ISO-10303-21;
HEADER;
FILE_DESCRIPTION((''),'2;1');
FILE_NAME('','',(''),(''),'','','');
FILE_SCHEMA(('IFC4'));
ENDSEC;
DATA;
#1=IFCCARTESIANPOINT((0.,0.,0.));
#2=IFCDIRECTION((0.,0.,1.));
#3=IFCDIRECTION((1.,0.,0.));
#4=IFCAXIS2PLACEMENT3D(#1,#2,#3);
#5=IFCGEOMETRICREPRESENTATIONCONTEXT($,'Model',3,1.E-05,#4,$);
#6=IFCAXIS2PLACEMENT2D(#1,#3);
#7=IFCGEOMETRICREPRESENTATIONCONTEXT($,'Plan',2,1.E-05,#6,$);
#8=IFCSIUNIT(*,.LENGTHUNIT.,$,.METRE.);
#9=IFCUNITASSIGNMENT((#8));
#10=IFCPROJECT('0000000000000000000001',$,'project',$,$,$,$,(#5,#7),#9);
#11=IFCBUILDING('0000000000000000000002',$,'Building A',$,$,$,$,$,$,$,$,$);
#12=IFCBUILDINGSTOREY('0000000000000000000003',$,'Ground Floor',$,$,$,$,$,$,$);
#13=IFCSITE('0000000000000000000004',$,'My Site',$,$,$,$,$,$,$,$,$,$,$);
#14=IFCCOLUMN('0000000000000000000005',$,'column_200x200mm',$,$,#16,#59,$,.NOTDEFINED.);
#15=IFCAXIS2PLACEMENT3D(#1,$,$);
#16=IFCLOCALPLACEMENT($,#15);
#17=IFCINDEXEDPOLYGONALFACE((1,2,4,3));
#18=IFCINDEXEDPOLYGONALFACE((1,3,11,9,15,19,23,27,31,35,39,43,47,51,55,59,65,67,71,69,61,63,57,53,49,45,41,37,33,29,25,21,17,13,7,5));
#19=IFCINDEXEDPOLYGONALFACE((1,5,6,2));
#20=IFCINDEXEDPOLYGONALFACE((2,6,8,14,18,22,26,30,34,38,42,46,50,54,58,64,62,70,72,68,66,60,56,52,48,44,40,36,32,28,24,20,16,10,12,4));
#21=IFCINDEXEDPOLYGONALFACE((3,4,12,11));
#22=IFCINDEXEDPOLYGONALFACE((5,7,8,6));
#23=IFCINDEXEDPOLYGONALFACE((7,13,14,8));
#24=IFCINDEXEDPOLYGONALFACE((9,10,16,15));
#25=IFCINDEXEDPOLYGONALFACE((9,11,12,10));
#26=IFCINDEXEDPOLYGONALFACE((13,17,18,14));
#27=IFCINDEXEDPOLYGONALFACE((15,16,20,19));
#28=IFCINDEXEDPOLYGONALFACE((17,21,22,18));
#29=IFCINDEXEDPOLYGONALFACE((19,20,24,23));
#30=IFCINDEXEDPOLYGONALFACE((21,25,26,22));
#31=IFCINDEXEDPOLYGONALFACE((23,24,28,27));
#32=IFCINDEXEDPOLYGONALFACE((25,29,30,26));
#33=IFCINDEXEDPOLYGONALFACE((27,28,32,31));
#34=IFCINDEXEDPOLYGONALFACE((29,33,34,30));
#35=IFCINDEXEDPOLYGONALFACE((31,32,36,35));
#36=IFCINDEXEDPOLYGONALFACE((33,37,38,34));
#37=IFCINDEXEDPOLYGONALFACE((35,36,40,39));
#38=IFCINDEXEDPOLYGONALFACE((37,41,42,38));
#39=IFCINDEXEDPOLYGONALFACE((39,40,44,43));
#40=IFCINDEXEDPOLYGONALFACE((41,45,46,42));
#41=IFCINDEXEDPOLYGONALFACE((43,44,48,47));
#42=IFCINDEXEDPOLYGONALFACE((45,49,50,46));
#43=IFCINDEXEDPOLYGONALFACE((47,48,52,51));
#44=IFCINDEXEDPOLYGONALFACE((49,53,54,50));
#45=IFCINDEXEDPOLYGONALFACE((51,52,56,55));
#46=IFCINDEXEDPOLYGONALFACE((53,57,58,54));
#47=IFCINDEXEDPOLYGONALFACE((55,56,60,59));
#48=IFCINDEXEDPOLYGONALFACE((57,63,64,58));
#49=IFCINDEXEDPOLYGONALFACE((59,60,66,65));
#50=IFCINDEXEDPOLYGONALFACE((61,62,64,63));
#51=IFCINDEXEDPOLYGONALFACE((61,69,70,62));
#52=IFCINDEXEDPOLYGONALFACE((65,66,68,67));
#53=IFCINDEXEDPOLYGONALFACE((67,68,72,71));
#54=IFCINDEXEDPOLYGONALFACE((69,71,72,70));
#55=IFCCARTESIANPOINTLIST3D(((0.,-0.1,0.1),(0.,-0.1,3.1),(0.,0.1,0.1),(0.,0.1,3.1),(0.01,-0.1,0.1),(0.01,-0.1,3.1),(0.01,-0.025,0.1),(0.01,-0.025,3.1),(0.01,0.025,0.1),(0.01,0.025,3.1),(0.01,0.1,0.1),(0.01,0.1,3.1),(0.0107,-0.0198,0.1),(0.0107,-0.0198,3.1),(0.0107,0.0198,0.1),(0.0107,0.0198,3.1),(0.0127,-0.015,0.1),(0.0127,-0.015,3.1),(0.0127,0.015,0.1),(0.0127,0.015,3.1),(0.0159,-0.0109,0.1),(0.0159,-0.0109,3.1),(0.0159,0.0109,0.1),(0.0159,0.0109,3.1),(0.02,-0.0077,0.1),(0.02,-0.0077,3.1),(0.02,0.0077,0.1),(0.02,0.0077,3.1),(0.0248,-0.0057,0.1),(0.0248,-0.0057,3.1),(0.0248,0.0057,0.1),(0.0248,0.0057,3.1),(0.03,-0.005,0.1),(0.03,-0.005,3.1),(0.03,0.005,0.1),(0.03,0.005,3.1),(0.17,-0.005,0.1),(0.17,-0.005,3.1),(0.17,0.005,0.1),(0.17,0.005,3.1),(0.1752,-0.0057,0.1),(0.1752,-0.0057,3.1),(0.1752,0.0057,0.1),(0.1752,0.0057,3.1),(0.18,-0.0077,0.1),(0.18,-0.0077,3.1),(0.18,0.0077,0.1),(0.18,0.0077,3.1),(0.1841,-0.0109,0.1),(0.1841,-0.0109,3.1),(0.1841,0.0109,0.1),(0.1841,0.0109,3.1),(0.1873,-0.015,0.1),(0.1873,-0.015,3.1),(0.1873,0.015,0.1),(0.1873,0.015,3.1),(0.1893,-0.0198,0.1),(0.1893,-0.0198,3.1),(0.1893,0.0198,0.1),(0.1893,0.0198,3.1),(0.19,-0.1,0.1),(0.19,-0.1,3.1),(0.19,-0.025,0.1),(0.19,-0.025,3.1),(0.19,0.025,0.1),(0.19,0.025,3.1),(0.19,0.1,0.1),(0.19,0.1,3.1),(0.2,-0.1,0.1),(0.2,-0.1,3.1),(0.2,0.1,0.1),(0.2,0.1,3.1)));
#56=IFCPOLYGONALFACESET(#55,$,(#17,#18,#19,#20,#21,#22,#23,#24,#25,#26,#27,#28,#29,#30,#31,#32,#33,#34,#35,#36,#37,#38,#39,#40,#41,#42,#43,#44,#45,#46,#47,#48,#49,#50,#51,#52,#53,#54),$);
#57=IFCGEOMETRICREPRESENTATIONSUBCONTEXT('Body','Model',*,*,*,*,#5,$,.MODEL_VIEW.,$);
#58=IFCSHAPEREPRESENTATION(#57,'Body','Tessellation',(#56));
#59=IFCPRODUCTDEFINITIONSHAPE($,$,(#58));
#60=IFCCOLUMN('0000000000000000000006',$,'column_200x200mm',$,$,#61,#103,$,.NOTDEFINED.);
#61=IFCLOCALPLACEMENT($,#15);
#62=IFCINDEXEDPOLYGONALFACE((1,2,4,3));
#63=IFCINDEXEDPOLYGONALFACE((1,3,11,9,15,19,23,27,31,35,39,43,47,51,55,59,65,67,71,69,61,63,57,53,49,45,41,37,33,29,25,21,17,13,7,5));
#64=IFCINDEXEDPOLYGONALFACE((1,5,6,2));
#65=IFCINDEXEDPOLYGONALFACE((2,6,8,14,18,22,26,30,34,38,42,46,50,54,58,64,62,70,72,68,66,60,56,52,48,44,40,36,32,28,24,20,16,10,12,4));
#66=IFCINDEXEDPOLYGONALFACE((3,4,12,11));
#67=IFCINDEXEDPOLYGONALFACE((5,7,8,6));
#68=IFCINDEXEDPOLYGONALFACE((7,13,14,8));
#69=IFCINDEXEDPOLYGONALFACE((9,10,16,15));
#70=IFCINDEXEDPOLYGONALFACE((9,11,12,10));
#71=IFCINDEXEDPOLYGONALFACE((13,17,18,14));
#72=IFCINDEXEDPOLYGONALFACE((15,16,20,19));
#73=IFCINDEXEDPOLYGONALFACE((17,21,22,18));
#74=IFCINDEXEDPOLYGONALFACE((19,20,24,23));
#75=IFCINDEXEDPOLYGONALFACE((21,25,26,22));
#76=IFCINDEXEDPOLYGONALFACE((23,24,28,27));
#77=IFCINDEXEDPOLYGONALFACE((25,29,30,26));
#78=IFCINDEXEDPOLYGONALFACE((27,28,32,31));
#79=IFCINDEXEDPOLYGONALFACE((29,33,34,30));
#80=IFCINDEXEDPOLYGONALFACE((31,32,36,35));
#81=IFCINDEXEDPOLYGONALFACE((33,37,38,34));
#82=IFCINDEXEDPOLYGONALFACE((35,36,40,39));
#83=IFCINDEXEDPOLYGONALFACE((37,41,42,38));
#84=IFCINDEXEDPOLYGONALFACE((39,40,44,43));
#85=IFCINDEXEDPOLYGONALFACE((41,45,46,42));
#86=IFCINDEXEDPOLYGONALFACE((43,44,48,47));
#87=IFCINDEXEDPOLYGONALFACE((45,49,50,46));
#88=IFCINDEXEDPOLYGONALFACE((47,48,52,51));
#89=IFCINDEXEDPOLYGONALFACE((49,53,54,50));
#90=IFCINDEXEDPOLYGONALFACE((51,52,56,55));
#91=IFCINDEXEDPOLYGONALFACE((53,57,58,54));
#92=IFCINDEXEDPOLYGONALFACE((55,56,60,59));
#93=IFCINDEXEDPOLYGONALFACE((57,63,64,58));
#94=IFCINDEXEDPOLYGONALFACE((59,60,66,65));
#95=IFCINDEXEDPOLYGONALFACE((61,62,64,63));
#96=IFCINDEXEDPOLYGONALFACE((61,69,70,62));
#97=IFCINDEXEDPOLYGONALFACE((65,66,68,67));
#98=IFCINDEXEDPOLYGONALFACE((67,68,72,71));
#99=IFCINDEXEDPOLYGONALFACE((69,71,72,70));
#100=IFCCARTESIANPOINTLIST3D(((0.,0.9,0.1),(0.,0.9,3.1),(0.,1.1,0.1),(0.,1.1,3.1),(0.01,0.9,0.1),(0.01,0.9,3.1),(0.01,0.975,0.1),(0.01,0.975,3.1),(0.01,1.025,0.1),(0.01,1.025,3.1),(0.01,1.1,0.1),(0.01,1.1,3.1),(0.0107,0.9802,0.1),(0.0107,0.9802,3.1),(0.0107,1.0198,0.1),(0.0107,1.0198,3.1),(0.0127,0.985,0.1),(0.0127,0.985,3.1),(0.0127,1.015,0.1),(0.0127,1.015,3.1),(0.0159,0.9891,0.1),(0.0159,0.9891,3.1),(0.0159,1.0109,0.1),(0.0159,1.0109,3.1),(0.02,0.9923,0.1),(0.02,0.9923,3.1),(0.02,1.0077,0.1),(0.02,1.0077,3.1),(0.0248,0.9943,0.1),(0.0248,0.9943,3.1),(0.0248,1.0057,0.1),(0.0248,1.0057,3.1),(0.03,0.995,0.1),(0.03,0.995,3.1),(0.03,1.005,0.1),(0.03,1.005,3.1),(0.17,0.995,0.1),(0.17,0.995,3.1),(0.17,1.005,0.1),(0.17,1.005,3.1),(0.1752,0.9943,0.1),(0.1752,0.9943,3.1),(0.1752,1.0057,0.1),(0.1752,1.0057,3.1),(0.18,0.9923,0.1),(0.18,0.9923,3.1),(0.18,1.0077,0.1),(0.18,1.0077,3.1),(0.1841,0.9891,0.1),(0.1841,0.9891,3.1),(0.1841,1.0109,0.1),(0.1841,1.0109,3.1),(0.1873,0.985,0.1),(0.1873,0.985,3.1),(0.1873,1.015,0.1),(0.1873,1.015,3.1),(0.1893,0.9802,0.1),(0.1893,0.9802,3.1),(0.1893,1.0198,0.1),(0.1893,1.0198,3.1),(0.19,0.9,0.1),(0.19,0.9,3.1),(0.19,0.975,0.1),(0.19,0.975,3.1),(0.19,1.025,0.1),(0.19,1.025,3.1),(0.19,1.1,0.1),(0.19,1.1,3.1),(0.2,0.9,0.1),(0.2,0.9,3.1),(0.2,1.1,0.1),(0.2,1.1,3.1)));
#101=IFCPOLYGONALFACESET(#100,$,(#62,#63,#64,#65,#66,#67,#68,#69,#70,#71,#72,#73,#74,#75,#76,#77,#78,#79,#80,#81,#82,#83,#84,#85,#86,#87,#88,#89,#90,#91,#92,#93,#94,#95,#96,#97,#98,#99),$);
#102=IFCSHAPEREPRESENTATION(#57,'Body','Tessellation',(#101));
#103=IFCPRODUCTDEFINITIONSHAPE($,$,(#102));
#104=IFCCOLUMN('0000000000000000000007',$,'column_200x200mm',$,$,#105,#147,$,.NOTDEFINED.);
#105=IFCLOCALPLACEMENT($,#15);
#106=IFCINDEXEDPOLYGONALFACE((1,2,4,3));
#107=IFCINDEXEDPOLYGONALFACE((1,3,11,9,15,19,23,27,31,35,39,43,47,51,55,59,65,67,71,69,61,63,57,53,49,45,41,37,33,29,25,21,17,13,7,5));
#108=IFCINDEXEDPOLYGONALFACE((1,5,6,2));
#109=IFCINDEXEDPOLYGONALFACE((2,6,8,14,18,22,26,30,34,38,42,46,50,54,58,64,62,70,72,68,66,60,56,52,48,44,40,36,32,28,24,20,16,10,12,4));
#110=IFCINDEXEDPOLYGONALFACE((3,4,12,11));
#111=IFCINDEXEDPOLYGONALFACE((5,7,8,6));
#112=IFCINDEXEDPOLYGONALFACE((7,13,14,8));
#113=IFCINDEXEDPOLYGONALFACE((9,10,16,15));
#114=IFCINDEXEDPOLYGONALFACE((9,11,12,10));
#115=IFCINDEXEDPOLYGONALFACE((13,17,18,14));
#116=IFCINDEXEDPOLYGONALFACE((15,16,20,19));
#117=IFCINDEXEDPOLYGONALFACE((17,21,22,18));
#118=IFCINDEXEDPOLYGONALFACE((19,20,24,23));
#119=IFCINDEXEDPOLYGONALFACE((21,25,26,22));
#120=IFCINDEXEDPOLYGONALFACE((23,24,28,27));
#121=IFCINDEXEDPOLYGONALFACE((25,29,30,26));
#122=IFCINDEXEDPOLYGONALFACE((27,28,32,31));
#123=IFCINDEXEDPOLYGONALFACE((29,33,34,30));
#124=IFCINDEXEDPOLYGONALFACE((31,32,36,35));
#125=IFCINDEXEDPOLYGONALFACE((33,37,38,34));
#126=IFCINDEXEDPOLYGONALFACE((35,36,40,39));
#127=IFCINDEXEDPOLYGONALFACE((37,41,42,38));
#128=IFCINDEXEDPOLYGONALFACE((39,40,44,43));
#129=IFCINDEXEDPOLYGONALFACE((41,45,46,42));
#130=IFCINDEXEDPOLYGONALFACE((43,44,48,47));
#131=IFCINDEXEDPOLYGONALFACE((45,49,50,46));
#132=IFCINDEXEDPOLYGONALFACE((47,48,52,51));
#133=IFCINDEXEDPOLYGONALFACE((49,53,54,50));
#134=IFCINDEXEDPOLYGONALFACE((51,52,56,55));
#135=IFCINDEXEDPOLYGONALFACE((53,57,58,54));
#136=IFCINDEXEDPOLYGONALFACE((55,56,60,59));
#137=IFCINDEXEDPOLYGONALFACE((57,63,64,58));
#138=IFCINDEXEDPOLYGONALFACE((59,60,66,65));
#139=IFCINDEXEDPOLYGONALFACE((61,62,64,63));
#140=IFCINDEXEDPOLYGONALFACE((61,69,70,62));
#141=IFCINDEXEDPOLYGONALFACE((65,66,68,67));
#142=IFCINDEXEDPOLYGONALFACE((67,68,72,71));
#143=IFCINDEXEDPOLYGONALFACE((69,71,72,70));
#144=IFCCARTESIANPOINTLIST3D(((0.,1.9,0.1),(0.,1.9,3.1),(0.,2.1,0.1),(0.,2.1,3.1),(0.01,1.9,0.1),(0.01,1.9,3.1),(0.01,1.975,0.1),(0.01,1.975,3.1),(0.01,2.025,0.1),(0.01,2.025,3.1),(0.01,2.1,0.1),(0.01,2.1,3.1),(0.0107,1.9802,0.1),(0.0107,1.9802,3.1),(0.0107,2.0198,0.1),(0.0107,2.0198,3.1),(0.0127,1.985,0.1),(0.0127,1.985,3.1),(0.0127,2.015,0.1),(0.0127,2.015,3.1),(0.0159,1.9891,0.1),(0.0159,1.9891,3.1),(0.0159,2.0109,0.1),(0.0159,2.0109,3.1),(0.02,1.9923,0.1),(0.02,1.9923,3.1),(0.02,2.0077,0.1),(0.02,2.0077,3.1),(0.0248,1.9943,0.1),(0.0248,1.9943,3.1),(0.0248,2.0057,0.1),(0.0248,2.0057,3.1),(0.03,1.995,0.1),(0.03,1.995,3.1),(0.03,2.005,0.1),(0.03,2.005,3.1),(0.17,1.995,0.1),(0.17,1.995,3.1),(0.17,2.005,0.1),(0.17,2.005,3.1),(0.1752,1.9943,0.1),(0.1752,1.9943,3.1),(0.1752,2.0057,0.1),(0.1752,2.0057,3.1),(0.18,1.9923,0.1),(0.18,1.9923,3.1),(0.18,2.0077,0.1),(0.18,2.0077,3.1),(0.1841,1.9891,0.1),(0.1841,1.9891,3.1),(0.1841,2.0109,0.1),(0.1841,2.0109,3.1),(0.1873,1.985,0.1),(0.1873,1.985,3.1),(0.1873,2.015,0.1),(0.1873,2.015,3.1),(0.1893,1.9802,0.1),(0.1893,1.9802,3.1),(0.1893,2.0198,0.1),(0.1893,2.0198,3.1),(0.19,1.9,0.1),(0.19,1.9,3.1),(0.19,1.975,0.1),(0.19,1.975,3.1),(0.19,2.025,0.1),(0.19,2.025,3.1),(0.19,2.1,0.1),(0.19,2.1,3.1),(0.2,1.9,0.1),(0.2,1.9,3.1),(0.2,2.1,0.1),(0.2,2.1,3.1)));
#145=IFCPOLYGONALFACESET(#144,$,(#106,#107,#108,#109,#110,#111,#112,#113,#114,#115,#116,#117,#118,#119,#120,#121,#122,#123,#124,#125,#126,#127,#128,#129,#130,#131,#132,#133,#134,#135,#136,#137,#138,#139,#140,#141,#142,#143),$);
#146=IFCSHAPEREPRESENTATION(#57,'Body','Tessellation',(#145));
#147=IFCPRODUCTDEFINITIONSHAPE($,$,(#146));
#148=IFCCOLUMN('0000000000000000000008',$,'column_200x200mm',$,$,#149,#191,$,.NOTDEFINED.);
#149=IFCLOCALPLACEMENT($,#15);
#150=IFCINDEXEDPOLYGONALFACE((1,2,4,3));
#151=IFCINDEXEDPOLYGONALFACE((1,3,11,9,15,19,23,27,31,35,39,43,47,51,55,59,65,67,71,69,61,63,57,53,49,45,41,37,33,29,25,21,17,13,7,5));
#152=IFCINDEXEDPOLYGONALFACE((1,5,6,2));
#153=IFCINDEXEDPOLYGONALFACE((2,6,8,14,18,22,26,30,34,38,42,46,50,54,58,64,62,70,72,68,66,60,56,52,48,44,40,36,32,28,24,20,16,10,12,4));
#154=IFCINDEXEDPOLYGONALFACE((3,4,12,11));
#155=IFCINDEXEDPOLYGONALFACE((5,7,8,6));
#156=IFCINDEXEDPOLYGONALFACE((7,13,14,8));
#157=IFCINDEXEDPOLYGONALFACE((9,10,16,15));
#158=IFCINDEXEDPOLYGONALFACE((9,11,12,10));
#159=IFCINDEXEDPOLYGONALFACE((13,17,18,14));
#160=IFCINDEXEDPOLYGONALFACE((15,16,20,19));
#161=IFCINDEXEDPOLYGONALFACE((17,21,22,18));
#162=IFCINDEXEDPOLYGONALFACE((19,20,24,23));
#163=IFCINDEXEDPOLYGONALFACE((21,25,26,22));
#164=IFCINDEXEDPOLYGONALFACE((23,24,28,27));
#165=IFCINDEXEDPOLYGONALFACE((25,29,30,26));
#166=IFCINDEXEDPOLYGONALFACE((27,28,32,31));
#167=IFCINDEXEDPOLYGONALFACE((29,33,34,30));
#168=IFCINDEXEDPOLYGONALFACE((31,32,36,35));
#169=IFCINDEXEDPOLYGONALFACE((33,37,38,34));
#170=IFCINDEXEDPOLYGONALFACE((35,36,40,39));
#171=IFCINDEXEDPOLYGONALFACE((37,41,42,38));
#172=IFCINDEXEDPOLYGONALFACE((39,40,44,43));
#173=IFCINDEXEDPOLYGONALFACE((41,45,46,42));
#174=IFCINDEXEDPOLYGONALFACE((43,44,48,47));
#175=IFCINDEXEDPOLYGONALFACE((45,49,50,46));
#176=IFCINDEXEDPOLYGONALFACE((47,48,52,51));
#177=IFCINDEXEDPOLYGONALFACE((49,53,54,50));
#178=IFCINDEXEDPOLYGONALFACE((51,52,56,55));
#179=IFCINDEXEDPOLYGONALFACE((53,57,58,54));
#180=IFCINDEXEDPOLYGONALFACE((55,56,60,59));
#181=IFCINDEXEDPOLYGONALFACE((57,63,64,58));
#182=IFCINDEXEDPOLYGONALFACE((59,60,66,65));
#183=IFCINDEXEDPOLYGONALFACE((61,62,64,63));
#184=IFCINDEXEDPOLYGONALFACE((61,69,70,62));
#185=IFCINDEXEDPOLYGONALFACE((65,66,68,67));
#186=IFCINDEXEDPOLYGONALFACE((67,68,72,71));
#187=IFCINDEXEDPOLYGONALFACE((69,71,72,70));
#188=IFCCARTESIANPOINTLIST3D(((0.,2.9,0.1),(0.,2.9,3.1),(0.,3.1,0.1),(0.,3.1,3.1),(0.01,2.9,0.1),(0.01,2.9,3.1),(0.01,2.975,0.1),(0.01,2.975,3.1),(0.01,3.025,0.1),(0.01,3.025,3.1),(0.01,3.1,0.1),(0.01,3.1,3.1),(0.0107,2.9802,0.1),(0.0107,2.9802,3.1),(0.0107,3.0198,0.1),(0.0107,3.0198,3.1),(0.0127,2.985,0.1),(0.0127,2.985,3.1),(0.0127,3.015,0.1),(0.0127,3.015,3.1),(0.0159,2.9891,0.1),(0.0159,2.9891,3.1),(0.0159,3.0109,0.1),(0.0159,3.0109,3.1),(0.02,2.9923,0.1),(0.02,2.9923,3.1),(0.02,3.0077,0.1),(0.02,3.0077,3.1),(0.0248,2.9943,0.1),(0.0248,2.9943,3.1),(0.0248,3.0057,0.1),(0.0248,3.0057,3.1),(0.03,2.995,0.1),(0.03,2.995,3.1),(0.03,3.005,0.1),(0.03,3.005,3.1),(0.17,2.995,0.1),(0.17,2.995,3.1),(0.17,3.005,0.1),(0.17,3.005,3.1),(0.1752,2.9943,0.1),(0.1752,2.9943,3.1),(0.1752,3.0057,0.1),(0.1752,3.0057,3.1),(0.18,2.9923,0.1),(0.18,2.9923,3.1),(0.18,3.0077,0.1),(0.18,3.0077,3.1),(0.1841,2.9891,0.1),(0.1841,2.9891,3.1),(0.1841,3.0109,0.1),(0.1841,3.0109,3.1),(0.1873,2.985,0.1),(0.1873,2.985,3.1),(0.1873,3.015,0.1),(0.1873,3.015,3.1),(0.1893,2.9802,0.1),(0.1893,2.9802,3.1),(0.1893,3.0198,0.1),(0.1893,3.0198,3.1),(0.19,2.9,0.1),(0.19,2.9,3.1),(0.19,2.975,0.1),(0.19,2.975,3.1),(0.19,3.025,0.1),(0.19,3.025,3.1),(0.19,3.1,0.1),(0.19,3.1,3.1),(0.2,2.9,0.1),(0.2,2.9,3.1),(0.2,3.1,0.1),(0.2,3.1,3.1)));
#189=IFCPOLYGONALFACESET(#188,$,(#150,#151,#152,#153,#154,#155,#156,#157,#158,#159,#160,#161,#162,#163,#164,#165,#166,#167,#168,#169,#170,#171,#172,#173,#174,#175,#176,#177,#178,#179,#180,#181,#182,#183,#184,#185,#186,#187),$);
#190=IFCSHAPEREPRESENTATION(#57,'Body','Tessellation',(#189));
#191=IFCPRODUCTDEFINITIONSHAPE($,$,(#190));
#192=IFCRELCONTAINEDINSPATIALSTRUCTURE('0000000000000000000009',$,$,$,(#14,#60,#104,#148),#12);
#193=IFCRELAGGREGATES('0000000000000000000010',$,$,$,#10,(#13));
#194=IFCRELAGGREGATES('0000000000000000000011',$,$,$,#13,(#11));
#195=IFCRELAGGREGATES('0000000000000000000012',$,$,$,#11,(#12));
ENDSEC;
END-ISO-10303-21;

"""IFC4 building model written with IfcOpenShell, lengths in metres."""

from ifc_helpers import new_model, entity, si_unit, frame, frame_2d, origin_with_axes, place, context, subcontext, project, spatial, extrude, element, save


model = new_model("IFC4")

# Units and contexts
model_context = context("Model", 3, precision=1e-05, world=origin_with_axes())
plan_context = context("Plan", 2, precision=1e-05, world=frame_2d((0.0, 0.0, 0.0), x_axis=(1.0, 0.0, 0.0)))
body_context = subcontext(model_context, "Body", "Model", "MODEL_VIEW")
ifc_project = project(units=[si_unit("LENGTHUNIT", "METRE")], contexts=[model_context, plan_context])

# Site, building, storey
site = spatial("IfcSite", under=ifc_project, Name="My Site")
building = spatial("IfcBuilding", under=site, Name="Building A")
storey = spatial("IfcBuildingStorey", under=building, Name="Ground Floor")

# Columns
for number, where, z_axis, x_axis, name in (
    (1, (0.1, 0.0, 0.1), (0.0, 0.0, 1.0), (0.0, 1.0, 0.0), "column_200x200mm"),
    (2, (0.1, 1.0, 0.1), (0.0, 0.0, 1.0), (0.0, 1.0, 0.0), "column_200x200mm"),
    (3, (0.1, 2.0, 0.1), (0.0, 0.0, 1.0), (0.0, 1.0, 0.0), "column_200x200mm"),
    (4, (0.1, 3.0, 0.1), (0.0, 0.0, 1.0), (0.0, 1.0, 0.0), "column_200x200mm"),
):
    element("IfcColumn", number, at=place(None, frame(where, z_axis=z_axis, x_axis=x_axis)), inside=storey, Name=name, PredefinedType="NOTDEFINED", context=body_context, shape_type="SweptSolid", body=[
        extrude(entity("IfcIShapeProfileDef", None, None, None, 0.2, 0.2, 0.01, 0.01, 0.02), origin_with_axes(), (0.0, 0.0, 1.0), 3.0),
    ])

save(model, "model.ifc")
